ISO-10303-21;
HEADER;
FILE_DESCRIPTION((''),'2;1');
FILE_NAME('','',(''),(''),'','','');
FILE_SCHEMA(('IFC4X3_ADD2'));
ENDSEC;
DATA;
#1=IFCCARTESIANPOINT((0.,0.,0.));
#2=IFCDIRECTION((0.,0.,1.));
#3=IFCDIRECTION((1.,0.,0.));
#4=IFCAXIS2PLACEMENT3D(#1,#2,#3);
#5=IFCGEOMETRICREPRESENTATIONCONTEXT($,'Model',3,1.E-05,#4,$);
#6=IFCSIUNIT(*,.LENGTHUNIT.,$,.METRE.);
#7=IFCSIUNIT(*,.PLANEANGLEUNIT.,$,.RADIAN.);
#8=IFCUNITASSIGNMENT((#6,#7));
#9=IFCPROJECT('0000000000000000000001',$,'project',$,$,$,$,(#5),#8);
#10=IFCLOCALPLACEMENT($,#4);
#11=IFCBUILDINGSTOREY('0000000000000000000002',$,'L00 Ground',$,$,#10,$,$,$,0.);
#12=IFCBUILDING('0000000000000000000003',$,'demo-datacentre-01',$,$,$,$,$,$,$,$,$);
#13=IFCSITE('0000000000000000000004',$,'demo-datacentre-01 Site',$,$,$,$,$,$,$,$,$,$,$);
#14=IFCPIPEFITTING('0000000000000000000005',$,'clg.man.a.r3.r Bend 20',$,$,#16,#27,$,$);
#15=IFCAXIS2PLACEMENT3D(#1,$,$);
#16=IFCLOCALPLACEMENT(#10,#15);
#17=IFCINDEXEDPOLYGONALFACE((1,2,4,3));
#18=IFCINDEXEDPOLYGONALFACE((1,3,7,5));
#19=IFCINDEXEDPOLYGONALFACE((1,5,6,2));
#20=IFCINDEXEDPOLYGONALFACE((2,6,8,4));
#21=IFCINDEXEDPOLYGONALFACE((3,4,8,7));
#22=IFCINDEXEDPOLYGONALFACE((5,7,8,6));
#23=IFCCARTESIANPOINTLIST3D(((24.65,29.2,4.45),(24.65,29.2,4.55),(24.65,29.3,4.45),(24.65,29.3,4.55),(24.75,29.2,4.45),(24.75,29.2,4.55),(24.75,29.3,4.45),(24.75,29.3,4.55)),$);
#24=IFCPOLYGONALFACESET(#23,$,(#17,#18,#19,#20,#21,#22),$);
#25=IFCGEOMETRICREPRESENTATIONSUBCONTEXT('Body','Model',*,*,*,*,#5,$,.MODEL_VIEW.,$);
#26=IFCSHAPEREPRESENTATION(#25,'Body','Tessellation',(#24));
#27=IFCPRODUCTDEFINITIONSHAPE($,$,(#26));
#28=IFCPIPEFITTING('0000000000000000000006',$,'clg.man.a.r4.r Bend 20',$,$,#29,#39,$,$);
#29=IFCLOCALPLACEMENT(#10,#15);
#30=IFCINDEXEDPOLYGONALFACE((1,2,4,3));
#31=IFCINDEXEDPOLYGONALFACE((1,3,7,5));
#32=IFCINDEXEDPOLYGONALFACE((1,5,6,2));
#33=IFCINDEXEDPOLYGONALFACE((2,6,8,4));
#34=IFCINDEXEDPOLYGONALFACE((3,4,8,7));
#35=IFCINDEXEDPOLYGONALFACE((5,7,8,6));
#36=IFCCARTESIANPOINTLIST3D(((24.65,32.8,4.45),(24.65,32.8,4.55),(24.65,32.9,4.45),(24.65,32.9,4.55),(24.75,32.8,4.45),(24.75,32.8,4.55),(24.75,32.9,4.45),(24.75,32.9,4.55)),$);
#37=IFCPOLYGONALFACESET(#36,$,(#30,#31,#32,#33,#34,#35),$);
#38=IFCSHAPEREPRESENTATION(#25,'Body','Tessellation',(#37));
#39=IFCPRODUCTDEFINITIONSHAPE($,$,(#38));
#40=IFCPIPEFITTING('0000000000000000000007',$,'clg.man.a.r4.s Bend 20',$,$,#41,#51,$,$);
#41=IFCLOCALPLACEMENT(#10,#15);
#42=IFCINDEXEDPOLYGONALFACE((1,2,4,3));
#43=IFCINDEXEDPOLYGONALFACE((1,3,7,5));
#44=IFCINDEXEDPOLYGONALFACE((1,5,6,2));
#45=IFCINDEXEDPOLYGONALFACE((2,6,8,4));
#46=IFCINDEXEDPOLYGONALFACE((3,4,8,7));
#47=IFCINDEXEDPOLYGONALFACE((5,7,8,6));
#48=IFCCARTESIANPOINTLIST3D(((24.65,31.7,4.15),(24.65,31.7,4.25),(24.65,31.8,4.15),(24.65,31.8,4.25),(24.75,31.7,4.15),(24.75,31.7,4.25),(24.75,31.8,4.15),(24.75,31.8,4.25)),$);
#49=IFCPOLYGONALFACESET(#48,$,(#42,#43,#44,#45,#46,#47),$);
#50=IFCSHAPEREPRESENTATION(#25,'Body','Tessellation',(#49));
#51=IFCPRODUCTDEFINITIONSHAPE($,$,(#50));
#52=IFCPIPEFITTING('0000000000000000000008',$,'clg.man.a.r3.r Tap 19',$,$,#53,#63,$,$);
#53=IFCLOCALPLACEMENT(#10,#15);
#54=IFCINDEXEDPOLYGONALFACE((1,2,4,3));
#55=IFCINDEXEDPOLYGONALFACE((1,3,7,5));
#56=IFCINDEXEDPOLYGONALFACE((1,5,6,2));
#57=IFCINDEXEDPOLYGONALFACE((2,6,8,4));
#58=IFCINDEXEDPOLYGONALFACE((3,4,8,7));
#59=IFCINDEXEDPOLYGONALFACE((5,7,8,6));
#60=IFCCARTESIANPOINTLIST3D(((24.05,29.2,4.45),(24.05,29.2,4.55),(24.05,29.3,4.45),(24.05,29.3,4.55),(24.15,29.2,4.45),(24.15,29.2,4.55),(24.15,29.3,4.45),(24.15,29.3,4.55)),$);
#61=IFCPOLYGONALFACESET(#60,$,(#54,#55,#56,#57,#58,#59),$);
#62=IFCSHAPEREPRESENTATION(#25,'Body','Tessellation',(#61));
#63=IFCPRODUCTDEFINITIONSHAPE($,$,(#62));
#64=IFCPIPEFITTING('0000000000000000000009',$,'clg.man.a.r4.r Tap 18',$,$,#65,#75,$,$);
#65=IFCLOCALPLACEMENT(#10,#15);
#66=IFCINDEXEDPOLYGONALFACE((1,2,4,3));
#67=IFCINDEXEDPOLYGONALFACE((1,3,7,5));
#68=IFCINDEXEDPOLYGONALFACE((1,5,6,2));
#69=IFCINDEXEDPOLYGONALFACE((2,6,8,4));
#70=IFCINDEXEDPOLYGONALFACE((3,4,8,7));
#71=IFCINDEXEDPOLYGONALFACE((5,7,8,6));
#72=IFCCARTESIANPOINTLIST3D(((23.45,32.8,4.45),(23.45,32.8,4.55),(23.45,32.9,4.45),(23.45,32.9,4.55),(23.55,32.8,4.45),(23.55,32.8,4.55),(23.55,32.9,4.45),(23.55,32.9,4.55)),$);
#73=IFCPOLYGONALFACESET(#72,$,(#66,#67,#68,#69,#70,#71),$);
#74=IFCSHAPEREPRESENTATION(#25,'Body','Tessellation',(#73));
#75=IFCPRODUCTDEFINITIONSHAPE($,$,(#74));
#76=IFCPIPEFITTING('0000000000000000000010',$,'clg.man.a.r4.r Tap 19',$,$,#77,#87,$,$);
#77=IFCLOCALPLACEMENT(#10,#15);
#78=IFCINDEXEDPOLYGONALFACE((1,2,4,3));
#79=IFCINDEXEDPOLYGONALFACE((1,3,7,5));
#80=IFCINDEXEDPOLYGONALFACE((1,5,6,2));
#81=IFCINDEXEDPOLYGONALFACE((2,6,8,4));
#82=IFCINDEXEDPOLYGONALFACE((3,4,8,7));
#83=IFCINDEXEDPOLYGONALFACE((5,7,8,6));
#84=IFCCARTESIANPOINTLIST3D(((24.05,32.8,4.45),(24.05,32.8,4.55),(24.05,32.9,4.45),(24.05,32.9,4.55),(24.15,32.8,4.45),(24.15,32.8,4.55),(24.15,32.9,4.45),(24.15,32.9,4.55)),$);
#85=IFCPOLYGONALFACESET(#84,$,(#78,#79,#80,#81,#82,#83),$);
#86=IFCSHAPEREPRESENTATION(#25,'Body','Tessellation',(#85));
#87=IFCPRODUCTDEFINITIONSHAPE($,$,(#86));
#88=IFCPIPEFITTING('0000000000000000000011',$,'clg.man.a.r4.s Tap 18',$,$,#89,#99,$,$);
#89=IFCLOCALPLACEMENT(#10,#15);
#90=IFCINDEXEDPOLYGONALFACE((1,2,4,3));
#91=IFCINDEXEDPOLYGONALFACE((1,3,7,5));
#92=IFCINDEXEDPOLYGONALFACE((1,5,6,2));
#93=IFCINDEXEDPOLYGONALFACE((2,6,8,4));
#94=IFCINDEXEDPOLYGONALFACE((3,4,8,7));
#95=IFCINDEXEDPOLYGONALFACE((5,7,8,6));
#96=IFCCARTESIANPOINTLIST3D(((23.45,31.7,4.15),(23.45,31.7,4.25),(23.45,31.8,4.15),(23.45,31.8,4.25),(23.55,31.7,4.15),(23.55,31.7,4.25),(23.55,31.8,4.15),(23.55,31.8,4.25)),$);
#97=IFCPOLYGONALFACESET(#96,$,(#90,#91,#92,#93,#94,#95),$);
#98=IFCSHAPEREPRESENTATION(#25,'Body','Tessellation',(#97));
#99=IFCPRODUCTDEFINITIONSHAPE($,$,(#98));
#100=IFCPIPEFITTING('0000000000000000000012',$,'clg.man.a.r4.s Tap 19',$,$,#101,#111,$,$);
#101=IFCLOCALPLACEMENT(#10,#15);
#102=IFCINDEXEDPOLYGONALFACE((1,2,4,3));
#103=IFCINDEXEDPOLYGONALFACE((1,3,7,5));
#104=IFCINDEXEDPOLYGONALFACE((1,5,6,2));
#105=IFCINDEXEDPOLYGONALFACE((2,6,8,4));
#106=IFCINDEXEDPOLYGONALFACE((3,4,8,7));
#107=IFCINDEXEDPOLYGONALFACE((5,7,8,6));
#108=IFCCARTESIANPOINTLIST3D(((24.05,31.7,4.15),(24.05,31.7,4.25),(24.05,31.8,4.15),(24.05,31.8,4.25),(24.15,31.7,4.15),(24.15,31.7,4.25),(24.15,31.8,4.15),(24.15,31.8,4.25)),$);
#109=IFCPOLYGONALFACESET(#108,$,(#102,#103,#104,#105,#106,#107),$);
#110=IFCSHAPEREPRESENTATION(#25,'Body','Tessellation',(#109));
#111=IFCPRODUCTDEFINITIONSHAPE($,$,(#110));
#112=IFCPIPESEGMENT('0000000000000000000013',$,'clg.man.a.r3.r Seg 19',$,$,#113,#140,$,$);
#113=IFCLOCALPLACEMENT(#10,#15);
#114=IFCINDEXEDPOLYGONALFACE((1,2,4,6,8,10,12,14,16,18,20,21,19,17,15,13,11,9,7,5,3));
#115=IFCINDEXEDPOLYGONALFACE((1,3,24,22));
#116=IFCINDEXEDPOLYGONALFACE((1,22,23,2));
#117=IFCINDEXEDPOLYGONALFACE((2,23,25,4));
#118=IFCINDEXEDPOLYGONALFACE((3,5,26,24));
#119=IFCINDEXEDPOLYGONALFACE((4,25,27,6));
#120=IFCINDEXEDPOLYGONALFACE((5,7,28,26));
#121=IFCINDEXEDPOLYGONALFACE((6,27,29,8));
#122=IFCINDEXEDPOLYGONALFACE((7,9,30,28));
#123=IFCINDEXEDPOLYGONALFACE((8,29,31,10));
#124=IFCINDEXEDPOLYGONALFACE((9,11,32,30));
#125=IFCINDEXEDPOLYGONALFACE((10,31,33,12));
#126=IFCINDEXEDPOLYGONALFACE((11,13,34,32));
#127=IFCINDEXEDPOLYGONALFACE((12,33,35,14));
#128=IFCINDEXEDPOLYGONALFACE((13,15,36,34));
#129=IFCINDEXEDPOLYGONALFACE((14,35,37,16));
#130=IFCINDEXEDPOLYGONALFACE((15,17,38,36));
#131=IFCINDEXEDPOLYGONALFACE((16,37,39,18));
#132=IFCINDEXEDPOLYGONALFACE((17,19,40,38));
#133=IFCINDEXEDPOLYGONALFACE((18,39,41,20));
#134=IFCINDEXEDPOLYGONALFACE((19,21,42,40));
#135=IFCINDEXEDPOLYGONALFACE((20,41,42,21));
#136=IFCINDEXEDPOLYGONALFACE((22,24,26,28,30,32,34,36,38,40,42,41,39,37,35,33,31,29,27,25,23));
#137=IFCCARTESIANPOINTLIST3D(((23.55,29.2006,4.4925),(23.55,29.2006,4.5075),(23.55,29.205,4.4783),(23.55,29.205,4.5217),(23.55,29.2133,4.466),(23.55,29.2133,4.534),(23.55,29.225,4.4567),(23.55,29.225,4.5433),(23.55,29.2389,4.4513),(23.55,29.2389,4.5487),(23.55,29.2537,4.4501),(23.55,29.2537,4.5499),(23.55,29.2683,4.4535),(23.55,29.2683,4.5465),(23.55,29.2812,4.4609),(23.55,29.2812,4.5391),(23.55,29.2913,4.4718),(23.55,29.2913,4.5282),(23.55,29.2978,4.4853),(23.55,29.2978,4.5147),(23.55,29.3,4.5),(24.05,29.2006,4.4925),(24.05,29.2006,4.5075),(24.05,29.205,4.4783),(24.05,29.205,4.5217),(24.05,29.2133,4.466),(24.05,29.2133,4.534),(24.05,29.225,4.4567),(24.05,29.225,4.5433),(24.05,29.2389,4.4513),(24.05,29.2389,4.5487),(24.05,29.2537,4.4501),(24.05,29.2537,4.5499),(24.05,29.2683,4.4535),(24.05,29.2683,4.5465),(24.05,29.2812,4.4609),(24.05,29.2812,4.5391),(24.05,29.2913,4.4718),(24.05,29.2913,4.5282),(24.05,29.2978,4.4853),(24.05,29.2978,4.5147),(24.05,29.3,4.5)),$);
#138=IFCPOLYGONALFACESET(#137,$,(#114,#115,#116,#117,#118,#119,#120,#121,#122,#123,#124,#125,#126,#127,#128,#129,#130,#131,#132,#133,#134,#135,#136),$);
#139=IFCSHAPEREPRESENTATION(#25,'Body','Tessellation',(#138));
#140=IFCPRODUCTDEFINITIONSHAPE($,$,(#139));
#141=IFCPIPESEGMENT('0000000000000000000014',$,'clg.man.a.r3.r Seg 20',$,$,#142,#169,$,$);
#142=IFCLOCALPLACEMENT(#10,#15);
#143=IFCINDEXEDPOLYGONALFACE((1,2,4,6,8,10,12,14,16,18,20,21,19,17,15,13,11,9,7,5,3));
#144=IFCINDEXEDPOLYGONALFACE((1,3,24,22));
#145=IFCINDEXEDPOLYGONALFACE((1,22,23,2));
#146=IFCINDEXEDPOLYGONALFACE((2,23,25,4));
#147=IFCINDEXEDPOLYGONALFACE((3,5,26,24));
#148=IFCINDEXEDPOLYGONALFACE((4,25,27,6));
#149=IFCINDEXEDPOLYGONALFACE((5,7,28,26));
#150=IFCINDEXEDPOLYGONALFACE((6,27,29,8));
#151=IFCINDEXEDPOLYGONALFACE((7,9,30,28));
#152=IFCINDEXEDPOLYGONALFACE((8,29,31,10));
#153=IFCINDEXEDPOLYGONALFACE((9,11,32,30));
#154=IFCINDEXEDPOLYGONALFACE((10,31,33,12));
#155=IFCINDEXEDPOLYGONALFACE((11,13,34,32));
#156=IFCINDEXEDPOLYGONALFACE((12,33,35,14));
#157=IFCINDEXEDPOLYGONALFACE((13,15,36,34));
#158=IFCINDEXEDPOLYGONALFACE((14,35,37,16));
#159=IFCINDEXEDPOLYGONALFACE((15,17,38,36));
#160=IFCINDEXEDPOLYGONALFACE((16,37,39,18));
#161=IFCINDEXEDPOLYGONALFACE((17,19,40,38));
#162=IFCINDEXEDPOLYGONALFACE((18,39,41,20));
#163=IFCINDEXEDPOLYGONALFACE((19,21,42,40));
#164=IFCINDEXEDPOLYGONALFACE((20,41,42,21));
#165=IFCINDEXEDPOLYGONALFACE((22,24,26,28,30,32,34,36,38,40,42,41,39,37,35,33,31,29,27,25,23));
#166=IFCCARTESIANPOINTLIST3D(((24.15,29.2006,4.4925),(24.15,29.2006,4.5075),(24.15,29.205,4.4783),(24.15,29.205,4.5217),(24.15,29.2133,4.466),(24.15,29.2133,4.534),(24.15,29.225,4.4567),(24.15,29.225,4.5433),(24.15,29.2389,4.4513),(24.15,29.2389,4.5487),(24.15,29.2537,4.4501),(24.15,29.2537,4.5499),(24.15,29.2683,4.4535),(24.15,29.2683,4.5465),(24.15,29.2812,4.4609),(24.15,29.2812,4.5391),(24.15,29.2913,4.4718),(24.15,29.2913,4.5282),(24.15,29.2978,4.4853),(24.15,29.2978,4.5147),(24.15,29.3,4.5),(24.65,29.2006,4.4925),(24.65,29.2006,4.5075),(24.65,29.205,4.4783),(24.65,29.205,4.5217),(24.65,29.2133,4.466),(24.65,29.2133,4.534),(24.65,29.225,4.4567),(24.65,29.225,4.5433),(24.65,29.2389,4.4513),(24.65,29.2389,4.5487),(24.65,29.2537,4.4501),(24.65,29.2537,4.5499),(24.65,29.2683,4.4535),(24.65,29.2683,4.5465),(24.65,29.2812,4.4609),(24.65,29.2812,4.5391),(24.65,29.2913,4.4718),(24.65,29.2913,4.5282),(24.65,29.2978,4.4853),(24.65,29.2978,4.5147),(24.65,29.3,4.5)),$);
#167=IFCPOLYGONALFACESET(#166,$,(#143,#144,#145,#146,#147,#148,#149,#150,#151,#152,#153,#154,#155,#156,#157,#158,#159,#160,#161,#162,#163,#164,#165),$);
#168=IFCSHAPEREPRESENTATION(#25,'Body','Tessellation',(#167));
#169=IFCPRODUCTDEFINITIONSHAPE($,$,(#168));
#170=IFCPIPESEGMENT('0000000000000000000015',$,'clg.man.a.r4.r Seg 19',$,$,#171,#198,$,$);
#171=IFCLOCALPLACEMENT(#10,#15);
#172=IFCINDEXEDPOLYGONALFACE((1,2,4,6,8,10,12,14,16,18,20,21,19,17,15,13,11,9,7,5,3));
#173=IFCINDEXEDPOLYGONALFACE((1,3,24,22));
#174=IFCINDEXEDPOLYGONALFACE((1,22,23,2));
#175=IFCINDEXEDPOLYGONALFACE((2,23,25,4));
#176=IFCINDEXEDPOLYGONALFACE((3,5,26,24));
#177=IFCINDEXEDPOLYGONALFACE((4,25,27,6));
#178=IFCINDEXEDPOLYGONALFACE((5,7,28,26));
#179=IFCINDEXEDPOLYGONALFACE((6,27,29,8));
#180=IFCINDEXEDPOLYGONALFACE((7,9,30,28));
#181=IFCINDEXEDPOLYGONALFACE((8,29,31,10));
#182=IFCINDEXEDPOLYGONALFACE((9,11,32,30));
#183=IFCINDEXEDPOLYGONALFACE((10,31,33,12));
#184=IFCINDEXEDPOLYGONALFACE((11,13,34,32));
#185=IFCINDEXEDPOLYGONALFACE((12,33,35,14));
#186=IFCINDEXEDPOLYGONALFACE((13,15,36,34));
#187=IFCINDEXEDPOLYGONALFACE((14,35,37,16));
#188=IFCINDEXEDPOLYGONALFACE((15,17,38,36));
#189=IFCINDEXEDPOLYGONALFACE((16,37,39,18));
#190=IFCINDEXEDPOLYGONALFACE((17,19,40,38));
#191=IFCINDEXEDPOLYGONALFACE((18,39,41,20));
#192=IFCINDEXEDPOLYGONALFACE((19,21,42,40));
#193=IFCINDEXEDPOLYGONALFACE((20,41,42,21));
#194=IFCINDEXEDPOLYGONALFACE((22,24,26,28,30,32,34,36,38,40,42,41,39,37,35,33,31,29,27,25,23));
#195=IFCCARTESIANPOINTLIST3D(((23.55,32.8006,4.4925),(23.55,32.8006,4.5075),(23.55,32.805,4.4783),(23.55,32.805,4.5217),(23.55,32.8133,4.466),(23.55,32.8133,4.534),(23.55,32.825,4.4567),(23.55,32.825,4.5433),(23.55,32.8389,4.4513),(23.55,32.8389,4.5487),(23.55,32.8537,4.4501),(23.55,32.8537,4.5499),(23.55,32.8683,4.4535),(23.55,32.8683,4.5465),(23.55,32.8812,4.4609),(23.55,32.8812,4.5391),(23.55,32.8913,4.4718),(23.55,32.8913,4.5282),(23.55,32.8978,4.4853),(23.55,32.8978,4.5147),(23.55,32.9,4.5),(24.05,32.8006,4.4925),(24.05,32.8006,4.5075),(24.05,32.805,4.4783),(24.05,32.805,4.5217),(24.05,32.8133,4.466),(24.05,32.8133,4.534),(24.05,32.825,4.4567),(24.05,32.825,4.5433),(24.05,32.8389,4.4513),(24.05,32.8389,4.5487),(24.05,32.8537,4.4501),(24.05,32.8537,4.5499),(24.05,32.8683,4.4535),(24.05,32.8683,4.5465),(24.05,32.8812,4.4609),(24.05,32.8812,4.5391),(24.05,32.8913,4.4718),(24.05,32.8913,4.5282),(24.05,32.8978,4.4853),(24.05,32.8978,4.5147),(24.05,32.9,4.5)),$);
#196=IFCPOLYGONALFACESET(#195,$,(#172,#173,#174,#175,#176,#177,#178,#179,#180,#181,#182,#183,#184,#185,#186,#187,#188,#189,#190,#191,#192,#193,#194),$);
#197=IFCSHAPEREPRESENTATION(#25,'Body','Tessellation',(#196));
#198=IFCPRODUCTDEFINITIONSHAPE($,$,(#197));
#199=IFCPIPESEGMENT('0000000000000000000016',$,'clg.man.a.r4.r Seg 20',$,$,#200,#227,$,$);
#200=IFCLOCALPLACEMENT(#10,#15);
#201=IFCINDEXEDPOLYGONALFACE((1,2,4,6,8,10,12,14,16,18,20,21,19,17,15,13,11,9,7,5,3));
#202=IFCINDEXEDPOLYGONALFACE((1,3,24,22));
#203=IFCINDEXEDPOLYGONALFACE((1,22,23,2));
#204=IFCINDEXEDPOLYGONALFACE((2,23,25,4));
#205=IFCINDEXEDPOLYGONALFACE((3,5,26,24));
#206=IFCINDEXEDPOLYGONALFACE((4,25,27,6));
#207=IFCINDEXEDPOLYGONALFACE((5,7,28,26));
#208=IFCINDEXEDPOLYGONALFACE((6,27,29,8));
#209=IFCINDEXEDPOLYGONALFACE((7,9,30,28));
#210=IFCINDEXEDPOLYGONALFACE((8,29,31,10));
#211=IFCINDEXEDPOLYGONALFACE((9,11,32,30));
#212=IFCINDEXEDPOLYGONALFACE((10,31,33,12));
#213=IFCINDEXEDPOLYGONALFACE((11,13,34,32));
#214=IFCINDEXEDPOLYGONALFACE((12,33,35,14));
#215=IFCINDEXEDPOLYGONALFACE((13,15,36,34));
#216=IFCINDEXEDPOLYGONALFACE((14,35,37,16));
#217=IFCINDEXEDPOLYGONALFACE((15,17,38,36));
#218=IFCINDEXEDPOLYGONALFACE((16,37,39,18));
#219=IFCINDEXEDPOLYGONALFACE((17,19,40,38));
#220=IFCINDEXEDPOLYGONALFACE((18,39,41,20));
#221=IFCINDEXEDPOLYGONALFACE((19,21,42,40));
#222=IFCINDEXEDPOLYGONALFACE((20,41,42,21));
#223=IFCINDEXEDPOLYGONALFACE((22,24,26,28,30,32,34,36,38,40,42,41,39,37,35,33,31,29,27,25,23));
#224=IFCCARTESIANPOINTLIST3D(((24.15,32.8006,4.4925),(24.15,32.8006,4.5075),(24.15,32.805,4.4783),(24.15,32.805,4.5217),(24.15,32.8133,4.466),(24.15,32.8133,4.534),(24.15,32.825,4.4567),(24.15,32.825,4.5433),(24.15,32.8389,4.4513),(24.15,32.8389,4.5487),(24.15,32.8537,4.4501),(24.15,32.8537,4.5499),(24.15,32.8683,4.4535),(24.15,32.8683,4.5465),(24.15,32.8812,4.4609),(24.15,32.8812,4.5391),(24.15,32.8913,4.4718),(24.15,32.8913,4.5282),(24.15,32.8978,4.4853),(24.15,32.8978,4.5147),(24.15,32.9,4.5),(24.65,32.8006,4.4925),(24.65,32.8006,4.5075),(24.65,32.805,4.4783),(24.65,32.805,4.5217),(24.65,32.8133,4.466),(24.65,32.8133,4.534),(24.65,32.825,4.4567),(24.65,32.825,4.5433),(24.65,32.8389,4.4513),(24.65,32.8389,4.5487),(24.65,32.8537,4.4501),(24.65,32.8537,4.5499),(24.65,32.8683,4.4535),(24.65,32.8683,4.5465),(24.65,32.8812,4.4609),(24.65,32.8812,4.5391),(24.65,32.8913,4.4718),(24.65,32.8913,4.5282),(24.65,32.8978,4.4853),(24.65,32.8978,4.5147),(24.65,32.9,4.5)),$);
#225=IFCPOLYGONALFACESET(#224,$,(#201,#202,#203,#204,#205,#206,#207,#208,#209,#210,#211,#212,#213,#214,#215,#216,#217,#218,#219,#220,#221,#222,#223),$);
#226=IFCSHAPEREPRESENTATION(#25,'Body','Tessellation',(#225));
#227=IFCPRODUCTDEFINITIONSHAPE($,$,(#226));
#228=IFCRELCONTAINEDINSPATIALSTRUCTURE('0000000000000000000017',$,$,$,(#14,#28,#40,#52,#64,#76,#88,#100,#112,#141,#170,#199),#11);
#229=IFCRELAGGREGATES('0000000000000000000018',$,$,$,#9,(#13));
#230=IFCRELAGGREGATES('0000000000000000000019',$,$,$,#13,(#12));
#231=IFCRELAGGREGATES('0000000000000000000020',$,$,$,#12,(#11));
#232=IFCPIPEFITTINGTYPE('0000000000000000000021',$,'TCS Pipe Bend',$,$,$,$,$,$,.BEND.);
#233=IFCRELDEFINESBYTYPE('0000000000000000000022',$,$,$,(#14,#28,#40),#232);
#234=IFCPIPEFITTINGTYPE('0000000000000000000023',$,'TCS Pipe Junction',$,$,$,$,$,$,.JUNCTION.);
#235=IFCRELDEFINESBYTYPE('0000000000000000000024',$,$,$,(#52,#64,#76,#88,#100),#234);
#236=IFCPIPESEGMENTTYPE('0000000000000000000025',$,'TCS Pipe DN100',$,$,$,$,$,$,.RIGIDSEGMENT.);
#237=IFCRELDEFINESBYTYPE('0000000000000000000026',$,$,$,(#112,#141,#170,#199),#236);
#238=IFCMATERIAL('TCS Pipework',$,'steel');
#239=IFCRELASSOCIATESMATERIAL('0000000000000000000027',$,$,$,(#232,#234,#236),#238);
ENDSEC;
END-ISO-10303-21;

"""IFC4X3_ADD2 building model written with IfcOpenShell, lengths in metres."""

from ifc_helpers import new_model, si_unit, frame, origin_with_axes, place, context, subcontext, project, spatial, rectangle, circle, extrude, material, type_object, element, save


model = new_model("IFC4X3_ADD2")

# Units and contexts
model_context = context("Model", 3, precision=1e-05, world=origin_with_axes())
body_context = subcontext(model_context, "Body", "Model", "MODEL_VIEW")
ifc_project = project(units=[si_unit("LENGTHUNIT", "METRE"), si_unit("PLANEANGLEUNIT", "RADIAN")], contexts=[model_context])

# Site, building, storey
site = spatial("IfcSite", under=ifc_project, Name="demo-datacentre-01 Site")
building = spatial("IfcBuilding", under=site, Name="demo-datacentre-01")
storey_placement = place(None, origin_with_axes())
storey = spatial("IfcBuildingStorey", under=building, at=storey_placement, Name="L00 Ground", Elevation=0.0)

# Pipe fittings
ifc_material = material(Name="TCS Pipework", Category="steel")
pipe_fitting_type_1 = type_object("IfcPipeFittingType", Name="TCS Pipe Bend", PredefinedType="BEND", material=ifc_material)
for number, where, z_axis, x_axis, name in (
    (1, (24.7, 29.25, 4.45), (0.0, 0.0, 1.0), (1.0, 0.0, 0.0), "clg.man.a.r3.r Bend 20"),
    (2, (24.7, 32.85, 4.45), (0.0, 0.0, 1.0), (1.0, 0.0, 0.0), "clg.man.a.r4.r Bend 20"),
    (3, (24.7, 31.75, 4.15), (0.0, 0.0, 1.0), (1.0, 0.0, 0.0), "clg.man.a.r4.s Bend 20"),
):
    element("IfcPipeFitting", number, at=place(storey_placement, frame(where, z_axis=z_axis, x_axis=x_axis)), inside=storey, type_object=pipe_fitting_type_1, Name=name, context=body_context, shape_type="SweptSolid", body=[
        extrude(rectangle(XDim=0.1, YDim=0.1), origin_with_axes(), (0.0, 0.0, 1.0), 0.1),
    ])
pipe_fitting_type_2 = type_object("IfcPipeFittingType", Name="TCS Pipe Junction", PredefinedType="JUNCTION", material=ifc_material)
for number, where, z_axis, x_axis, name in (
    (4, (24.1, 29.25, 4.45), (0.0, 0.0, 1.0), (1.0, 0.0, 0.0), "clg.man.a.r3.r Tap 19"),
    (5, (23.5, 32.85, 4.45), (0.0, 0.0, 1.0), (1.0, 0.0, 0.0), "clg.man.a.r4.r Tap 18"),
    (6, (24.1, 32.85, 4.45), (0.0, 0.0, 1.0), (1.0, 0.0, 0.0), "clg.man.a.r4.r Tap 19"),
    (7, (23.5, 31.75, 4.15), (0.0, 0.0, 1.0), (1.0, 0.0, 0.0), "clg.man.a.r4.s Tap 18"),
    (8, (24.1, 31.75, 4.15), (0.0, 0.0, 1.0), (1.0, 0.0, 0.0), "clg.man.a.r4.s Tap 19"),
):
    element("IfcPipeFitting", number, at=place(storey_placement, frame(where, z_axis=z_axis, x_axis=x_axis)), inside=storey, type_object=pipe_fitting_type_2, Name=name, context=body_context, shape_type="SweptSolid", body=[
        extrude(rectangle(XDim=0.1, YDim=0.1), origin_with_axes(), (0.0, 0.0, 1.0), 0.1),
    ])

# Pipe segments
pipe_segment_type_1 = type_object("IfcPipeSegmentType", Name="TCS Pipe DN100", PredefinedType="RIGIDSEGMENT", material=ifc_material)
for number, where, z_axis, x_axis, name in (
    (9, (23.55, 29.25, 4.5), (1.0, 0.0, 0.0), (0.0, 1.0, 0.0), "clg.man.a.r3.r Seg 19"),
    (10, (24.15, 29.25, 4.5), (1.0, 0.0, 0.0), (0.0, 1.0, 0.0), "clg.man.a.r3.r Seg 20"),
    (11, (23.55, 32.85, 4.5), (1.0, 0.0, 0.0), (0.0, 1.0, 0.0), "clg.man.a.r4.r Seg 19"),
    (12, (24.15, 32.85, 4.5), (1.0, 0.0, 0.0), (0.0, 1.0, 0.0), "clg.man.a.r4.r Seg 20"),
):
    element("IfcPipeSegment", number, at=place(storey_placement, frame(where, z_axis=z_axis, x_axis=x_axis)), inside=storey, type_object=pipe_segment_type_1, Name=name, context=body_context, shape_type="SweptSolid", body=[
        extrude(circle(Radius=0.05), origin_with_axes(), (0.0, 0.0, 1.0), 0.5),
    ])

save(model, "model.ifc")
